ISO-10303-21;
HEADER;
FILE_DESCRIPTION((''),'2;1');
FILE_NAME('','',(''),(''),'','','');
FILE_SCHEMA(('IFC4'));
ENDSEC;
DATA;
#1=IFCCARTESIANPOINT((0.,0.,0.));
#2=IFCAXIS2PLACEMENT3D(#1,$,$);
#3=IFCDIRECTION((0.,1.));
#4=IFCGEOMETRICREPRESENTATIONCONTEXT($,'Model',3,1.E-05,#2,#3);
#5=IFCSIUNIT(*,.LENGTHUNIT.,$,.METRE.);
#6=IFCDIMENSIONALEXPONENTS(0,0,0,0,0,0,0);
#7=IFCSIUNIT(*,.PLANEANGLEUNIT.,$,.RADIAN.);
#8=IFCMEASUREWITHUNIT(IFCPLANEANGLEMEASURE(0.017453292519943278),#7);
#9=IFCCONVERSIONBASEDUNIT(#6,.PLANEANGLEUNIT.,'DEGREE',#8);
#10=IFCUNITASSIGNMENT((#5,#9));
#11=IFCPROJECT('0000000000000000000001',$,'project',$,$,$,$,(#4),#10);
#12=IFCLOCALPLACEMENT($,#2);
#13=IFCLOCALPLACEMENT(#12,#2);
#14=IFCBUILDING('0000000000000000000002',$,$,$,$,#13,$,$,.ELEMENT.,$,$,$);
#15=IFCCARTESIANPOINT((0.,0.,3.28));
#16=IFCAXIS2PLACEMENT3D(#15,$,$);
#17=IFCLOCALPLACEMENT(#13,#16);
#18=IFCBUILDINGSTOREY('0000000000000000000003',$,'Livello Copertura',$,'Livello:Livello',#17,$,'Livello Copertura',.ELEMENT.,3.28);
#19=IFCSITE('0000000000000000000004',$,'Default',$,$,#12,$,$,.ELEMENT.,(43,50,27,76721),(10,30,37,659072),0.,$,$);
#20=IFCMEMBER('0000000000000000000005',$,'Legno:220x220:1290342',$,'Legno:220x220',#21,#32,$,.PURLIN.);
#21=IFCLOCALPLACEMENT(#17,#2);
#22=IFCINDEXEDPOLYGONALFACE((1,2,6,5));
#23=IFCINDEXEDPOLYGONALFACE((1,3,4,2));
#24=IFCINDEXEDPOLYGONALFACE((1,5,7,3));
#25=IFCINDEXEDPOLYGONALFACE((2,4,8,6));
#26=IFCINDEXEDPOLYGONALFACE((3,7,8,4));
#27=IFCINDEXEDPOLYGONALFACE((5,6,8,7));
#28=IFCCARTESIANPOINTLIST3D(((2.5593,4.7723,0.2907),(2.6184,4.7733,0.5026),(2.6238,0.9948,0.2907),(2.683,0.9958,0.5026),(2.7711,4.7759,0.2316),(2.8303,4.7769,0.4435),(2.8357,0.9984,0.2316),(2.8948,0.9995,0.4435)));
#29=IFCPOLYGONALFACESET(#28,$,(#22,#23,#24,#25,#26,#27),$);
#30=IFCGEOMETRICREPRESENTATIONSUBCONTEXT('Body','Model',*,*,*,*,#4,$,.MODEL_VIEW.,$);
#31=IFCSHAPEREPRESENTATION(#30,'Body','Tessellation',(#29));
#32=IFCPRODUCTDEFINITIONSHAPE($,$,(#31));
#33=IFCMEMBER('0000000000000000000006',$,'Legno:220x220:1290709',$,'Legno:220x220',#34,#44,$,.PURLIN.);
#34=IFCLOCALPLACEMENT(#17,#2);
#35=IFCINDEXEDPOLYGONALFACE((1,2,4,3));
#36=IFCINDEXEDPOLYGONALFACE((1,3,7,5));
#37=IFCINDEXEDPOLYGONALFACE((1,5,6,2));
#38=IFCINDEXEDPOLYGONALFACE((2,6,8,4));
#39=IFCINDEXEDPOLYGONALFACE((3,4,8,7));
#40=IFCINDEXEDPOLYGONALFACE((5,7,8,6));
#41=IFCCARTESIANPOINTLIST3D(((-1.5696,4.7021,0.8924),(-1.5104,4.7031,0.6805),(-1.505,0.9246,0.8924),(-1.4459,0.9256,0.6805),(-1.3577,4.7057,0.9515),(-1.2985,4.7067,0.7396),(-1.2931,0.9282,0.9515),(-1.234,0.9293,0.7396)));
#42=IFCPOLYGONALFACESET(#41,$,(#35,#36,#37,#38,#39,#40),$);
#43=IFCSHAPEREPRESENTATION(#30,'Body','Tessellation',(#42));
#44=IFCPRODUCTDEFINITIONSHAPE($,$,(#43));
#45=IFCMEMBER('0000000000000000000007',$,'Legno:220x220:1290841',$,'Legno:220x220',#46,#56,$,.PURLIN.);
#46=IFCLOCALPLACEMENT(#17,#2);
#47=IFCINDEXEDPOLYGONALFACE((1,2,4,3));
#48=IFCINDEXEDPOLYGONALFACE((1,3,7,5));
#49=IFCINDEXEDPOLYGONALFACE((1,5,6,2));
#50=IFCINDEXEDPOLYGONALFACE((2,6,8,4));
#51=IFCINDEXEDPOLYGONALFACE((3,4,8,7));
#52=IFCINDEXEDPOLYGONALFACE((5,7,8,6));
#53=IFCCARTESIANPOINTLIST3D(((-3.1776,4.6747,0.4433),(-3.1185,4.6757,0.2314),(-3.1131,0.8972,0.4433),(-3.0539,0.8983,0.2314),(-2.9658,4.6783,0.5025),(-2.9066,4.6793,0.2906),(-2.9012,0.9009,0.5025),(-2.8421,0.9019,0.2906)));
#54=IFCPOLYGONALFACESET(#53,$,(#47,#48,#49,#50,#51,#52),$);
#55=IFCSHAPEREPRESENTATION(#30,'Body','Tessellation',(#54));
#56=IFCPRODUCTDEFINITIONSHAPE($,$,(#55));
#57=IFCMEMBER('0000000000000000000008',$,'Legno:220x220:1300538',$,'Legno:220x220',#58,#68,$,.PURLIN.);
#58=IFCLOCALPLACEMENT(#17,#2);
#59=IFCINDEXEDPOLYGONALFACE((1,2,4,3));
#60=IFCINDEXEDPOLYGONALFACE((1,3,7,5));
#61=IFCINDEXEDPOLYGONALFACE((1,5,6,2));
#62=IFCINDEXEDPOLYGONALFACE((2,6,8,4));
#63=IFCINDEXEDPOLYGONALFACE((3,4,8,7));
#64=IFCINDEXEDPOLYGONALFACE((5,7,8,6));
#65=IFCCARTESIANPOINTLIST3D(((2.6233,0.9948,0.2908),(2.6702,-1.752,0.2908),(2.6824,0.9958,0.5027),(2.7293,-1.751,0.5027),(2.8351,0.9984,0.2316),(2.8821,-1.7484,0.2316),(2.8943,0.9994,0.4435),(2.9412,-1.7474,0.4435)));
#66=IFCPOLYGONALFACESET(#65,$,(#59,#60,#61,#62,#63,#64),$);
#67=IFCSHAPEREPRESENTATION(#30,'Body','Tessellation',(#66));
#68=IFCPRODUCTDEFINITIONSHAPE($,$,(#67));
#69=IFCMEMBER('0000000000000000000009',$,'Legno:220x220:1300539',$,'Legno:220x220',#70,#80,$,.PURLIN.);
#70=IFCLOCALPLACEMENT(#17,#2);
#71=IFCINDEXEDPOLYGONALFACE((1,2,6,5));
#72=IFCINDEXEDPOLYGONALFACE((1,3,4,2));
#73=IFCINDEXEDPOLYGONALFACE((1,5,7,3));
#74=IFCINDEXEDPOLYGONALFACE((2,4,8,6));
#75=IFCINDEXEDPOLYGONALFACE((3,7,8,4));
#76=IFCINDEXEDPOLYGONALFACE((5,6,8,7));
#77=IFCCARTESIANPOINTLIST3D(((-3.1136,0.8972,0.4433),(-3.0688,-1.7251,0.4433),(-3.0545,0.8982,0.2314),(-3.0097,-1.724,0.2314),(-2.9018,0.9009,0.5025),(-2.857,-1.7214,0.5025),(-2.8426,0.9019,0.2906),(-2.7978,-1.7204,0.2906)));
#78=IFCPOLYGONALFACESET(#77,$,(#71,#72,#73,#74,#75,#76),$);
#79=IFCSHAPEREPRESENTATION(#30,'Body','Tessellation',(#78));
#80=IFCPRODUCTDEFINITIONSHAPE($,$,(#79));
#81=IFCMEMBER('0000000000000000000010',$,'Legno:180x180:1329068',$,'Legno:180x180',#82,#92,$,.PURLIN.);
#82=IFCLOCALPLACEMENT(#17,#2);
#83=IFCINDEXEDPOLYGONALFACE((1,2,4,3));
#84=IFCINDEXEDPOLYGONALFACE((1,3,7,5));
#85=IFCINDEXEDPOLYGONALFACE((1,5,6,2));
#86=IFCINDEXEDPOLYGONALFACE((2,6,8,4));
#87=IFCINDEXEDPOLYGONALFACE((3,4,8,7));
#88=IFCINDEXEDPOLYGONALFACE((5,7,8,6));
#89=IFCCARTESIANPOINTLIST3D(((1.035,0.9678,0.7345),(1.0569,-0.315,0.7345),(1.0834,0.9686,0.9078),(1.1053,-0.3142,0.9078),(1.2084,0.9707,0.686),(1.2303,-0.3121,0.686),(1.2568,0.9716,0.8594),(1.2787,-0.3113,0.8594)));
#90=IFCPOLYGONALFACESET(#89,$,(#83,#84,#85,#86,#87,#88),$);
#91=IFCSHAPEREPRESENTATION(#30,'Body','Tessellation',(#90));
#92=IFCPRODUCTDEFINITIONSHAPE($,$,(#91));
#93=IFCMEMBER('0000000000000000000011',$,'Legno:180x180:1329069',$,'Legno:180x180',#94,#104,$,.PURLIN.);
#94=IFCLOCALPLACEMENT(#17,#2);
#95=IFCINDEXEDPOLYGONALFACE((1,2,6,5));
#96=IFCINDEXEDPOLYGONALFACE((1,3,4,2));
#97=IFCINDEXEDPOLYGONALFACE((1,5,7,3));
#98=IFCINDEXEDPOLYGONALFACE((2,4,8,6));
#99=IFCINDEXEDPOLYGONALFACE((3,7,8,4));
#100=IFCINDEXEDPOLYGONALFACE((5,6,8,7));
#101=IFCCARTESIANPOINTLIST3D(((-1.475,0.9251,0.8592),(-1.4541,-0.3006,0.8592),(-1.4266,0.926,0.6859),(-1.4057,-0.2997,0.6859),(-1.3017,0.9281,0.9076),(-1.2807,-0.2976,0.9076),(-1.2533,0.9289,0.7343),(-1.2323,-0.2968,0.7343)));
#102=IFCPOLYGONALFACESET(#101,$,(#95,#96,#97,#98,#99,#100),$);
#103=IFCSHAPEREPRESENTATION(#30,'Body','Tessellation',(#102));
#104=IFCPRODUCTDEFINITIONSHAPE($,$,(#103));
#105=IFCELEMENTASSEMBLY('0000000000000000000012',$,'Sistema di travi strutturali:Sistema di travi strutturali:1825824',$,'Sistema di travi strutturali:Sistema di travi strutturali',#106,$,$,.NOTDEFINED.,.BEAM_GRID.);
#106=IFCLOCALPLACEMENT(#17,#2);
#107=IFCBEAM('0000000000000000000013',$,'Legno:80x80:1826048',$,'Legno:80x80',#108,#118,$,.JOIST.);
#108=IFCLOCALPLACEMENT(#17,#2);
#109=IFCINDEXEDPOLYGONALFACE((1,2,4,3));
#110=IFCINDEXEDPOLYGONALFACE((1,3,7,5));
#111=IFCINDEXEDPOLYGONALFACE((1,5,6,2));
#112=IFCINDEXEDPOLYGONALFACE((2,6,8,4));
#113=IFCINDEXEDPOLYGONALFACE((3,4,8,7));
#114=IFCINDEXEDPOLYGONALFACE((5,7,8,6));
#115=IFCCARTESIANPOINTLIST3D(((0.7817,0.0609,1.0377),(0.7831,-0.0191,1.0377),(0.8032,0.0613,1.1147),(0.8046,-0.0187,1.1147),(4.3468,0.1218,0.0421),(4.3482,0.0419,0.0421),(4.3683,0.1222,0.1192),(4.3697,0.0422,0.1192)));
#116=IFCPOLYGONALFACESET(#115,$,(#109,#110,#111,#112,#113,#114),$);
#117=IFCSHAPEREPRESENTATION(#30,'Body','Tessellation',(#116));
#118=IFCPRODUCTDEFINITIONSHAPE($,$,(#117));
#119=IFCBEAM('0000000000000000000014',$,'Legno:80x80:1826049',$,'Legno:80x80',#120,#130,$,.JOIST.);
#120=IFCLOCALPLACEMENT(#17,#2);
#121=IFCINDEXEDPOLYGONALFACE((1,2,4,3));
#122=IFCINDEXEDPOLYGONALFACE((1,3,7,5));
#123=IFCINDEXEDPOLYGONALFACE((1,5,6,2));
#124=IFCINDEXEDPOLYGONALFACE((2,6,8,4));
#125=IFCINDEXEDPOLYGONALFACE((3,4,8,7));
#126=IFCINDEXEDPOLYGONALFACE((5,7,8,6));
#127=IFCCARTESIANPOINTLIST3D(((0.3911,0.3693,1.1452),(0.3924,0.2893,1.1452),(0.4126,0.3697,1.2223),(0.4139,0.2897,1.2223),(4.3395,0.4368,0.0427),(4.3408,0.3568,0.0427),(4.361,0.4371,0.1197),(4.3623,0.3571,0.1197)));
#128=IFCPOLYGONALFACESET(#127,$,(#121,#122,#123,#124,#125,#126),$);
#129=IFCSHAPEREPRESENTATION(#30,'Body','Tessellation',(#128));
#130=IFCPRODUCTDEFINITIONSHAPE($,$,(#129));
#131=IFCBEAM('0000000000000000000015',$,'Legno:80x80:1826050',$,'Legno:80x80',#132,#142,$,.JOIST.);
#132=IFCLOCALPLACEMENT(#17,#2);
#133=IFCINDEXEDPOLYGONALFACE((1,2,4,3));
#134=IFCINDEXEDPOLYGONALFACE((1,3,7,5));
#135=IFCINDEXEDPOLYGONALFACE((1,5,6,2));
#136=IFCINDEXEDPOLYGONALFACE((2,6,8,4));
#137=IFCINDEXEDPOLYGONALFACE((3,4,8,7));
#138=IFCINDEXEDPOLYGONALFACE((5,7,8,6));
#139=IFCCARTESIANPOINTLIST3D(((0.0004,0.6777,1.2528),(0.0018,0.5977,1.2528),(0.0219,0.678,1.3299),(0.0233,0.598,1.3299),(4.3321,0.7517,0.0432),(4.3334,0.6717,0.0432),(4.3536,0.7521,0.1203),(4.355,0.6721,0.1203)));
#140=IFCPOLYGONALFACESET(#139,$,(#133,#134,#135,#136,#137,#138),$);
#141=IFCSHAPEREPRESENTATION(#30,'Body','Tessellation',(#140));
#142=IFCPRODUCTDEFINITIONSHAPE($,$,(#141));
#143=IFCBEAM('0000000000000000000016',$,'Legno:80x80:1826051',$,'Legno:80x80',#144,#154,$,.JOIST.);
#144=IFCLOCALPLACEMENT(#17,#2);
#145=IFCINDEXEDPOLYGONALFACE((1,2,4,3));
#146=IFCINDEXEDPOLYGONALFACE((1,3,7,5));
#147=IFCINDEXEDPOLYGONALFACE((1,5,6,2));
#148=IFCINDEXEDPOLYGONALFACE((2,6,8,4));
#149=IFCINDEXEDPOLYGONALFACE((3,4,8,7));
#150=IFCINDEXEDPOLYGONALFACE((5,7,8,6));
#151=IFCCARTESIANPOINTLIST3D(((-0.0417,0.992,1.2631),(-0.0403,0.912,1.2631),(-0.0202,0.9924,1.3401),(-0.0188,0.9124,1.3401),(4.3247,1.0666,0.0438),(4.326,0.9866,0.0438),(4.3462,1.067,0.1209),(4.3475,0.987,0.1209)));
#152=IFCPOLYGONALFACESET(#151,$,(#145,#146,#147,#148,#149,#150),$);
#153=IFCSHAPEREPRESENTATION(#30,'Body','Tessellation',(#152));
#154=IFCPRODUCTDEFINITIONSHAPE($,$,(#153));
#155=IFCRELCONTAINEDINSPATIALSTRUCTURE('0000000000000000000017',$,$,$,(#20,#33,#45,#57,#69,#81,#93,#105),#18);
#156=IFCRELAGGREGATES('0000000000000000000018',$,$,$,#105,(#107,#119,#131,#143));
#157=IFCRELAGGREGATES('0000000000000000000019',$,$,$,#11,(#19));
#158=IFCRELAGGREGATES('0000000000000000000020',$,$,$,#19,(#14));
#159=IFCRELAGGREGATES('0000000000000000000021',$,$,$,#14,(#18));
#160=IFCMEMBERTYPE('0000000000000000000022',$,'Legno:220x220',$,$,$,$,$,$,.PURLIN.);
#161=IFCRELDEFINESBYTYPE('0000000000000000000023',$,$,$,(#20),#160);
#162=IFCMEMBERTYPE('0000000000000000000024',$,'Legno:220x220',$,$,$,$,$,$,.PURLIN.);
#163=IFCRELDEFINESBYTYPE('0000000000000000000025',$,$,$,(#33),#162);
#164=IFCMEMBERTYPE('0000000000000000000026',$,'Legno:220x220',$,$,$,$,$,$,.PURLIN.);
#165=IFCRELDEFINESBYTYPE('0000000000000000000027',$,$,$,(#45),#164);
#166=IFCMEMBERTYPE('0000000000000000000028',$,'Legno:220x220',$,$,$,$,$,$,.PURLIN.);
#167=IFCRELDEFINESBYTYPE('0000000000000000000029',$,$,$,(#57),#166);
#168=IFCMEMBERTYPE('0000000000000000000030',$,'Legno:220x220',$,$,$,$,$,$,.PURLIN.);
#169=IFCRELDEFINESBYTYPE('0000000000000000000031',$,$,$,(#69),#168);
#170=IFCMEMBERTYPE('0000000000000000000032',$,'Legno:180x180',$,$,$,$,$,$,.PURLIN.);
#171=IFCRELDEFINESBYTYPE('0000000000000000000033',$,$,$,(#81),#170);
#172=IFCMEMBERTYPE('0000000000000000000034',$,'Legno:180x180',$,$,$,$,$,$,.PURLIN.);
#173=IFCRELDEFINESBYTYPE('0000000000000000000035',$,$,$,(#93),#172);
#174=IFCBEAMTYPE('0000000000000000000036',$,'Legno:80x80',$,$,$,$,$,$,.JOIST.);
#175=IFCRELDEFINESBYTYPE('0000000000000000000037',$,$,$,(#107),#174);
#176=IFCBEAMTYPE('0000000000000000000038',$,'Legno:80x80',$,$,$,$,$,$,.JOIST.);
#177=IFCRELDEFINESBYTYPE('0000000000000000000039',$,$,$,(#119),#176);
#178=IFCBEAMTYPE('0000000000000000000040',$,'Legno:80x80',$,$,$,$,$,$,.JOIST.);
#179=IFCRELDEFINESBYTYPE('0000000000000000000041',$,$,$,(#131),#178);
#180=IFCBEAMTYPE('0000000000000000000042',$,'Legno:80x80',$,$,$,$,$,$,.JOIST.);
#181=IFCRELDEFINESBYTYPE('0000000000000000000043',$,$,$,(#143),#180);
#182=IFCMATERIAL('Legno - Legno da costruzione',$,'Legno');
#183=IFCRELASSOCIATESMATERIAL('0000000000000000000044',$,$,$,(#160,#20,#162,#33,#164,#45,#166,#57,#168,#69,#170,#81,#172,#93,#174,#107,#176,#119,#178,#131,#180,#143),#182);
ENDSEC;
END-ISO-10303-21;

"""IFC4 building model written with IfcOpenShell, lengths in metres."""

from ifc_helpers import new_model, entity, si_unit, converted_unit, direction, frame, origin, place, context, subcontext, project, spatial, indexed_curve, outline, extrude, source, transform, mapped, material, type_object, type_shapes, element, aggregate, save


model = new_model("IFC4")

# Units and contexts
model_context = context("Model", 3, precision=1e-05, world=origin(), true_north=direction((0.0, 1.0)))
body_context = subcontext(model_context, "Body", "Model", "MODEL_VIEW")
ifc_project = project(units=[si_unit("LENGTHUNIT", "METRE"), converted_unit("PLANEANGLEUNIT", "DEGREE", entity("IfcPlaneAngleMeasure", 0.017453292519943278), si_unit("PLANEANGLEUNIT", "RADIAN"), dimensions=[0, 0, 0, 0, 0, 0, 0])], contexts=[model_context])

# Site, building, storey
site_placement = place(None, origin())
site = spatial("IfcSite", under=ifc_project, at=site_placement, Name="Default", CompositionType="ELEMENT", RefLatitude=(43, 50, 27, 76721), RefLongitude=(10, 30, 37, 659072), RefElevation=0.0)
building_placement = place(site_placement, origin())
building = spatial("IfcBuilding", under=site, at=building_placement, CompositionType="ELEMENT")
storey_placement = place(building_placement, frame((0.0, 0.0, 3.28)))
storey = spatial("IfcBuildingStorey", under=building, at=storey_placement, Name="Livello Copertura", ObjectType="Livello:Livello", LongName="Livello Copertura", CompositionType="ELEMENT", Elevation=3.28)

# Members
ifc_material = material(Name="Legno - Legno da costruzione", Category="Legno")
member_type_1 = type_object("IfcMemberType", Name="Legno:220x220", PredefinedType="PURLIN", material=ifc_material)
shared_shape_1 = source(origin(), body_context, "Body", "SweptSolid", [
    extrude(outline(indexed_curve([(-0.11, -0.11), (0.11, -0.11), (0.11, 0.11), (-0.11, 0.11), (-0.11, -0.11)], self_intersect=False)), frame((2.6948, 4.7746, 3.6471), z_axis=(0.017085, -0.999854, 0.0), x_axis=(-0.963022, -0.016456, 0.26892)), (0.0, 0.0, 1.0), 3.778),
])
type_shapes(member_type_1, [shared_shape_1])
member_1_placement = place(storey_placement, frame((0.0, 0.0, -3.28)))
element("IfcMember", 1, at=member_1_placement, inside=storey, type_object=member_type_1, material=ifc_material, Name="Legno:220x220:1290342", ObjectType="Legno:220x220", PredefinedType="PURLIN", context=body_context, shape_type="MappedRepresentation", body=[
    mapped(shared_shape_1, transform((0.0, 0.0, 0.0), scale=1.0)),
])
member_type_2 = type_object("IfcMemberType", Name="Legno:220x220", PredefinedType="PURLIN", material=ifc_material)
shared_shape_2 = source(origin(), body_context, "Body", "SweptSolid", [
    extrude(outline(indexed_curve([(-0.11, -0.11), (0.11, -0.11), (0.11, 0.11), (-0.11, 0.11), (-0.11, -0.11)], self_intersect=False)), frame((-1.434, 4.7044, 4.096), z_axis=(0.017085, -0.999854, 0.0), x_axis=(-0.963022, -0.016456, -0.26892)), (0.0, 0.0, 1.0), 3.778),
])
type_shapes(member_type_2, [shared_shape_2])
member_2_placement = place(storey_placement, frame((0.0, 0.0, -3.28)))
element("IfcMember", 2, at=member_2_placement, inside=storey, type_object=member_type_2, material=ifc_material, Name="Legno:220x220:1290709", ObjectType="Legno:220x220", PredefinedType="PURLIN", context=body_context, shape_type="MappedRepresentation", body=[
    mapped(shared_shape_2, transform((0.0, 0.0, 0.0), scale=1.0)),
])
member_type_3 = type_object("IfcMemberType", Name="Legno:220x220", PredefinedType="PURLIN", material=ifc_material)
shared_shape_3 = source(origin(), body_context, "Body", "SweptSolid", [
    extrude(outline(indexed_curve([(-0.11, -0.11), (0.11, -0.11), (0.11, 0.11), (-0.11, 0.11), (-0.11, -0.11)], self_intersect=False)), frame((-3.0421, 4.677, 3.647), z_axis=(0.017085, -0.999854, 0.0), x_axis=(-0.963022, -0.016456, -0.26892)), (0.0, 0.0, 1.0), 3.778),
])
type_shapes(member_type_3, [shared_shape_3])
member_3_placement = place(storey_placement, frame((0.0, 0.0, -3.28)))
element("IfcMember", 3, at=member_3_placement, inside=storey, type_object=member_type_3, material=ifc_material, Name="Legno:220x220:1290841", ObjectType="Legno:220x220", PredefinedType="PURLIN", context=body_context, shape_type="MappedRepresentation", body=[
    mapped(shared_shape_3, transform((0.0, 0.0, 0.0), scale=1.0)),
])
member_type_4 = type_object("IfcMemberType", Name="Legno:220x220", PredefinedType="PURLIN", material=ifc_material)
shared_shape_4 = source(origin(), body_context, "Body", "SweptSolid", [
    extrude(outline(indexed_curve([(-0.11, -0.11), (0.11, -0.11), (0.11, 0.11), (-0.11, 0.11), (-0.11, -0.11)], self_intersect=False)), frame((2.7588, 0.9971, 3.6471), z_axis=(0.017085, -0.999854, 0.0), x_axis=(-0.963022, -0.016456, 0.26892)), (0.0, 0.0, 1.0), 2.7472),
])
type_shapes(member_type_4, [shared_shape_4])
member_4_placement = place(storey_placement, frame((0.0, 0.0, -3.28)))
element("IfcMember", 4, at=member_4_placement, inside=storey, type_object=member_type_4, material=ifc_material, Name="Legno:220x220:1300538", ObjectType="Legno:220x220", PredefinedType="PURLIN", context=body_context, shape_type="MappedRepresentation", body=[
    mapped(shared_shape_4, transform((0.0, 0.0, 0.0), scale=1.0)),
])
member_type_5 = type_object("IfcMemberType", Name="Legno:220x220", PredefinedType="PURLIN", material=ifc_material)
shared_shape_5 = source(origin(), body_context, "Body", "SweptSolid", [
    extrude(outline(indexed_curve([(-0.11, -0.11), (0.11, -0.11), (0.11, 0.11), (-0.11, 0.11), (-0.11, -0.11)], self_intersect=False)), frame((-2.9781, 0.8995, 3.647), z_axis=(0.017085, -0.999854, 0.0), x_axis=(-0.963022, -0.016456, -0.26892)), (0.0, 0.0, 1.0), 2.6227),
])
type_shapes(member_type_5, [shared_shape_5])
member_5_placement = place(storey_placement, frame((0.0, 0.0, -3.28)))
element("IfcMember", 5, at=member_5_placement, inside=storey, type_object=member_type_5, material=ifc_material, Name="Legno:220x220:1300539", ObjectType="Legno:220x220", PredefinedType="PURLIN", context=body_context, shape_type="MappedRepresentation", body=[
    mapped(shared_shape_5, transform((0.0, 0.0, 0.0), scale=1.0)),
])
member_type_6 = type_object("IfcMemberType", Name="Legno:180x180", PredefinedType="PURLIN", material=ifc_material)
shared_shape_6 = source(origin(), body_context, "Body", "SweptSolid", [
    extrude(outline(indexed_curve([(-0.09, -0.09), (0.09, -0.09), (0.09, 0.09), (-0.09, 0.09), (-0.09, -0.09)], self_intersect=False)), frame((1.1459, 0.9697, 4.0769), z_axis=(0.017085, -0.999854, 0.0), x_axis=(-0.963022, -0.016456, 0.26892)), (0.0, 0.0, 1.0), 1.283),
])
type_shapes(member_type_6, [shared_shape_6])
member_6_placement = place(storey_placement, frame((0.0, 0.0, -3.28)))
element("IfcMember", 6, at=member_6_placement, inside=storey, type_object=member_type_6, material=ifc_material, Name="Legno:180x180:1329068", ObjectType="Legno:180x180", PredefinedType="PURLIN", context=body_context, shape_type="MappedRepresentation", body=[
    mapped(shared_shape_6, transform((0.0, 0.0, 0.0), scale=1.0)),
])
member_type_7 = type_object("IfcMemberType", Name="Legno:180x180", PredefinedType="PURLIN", material=ifc_material)
shared_shape_7 = source(origin(), body_context, "Body", "SweptSolid", [
    extrude(outline(indexed_curve([(-0.09, -0.09), (0.09, -0.09), (0.09, 0.09), (-0.09, 0.09), (-0.09, -0.09)], self_intersect=False)), frame((-1.3641, 0.927, 4.0767), z_axis=(0.017085, -0.999854, 0.0), x_axis=(-0.963022, -0.016456, -0.26892)), (0.0, 0.0, 1.0), 1.2259),
])
type_shapes(member_type_7, [shared_shape_7])
member_7_placement = place(storey_placement, frame((0.0, 0.0, -3.28)))
element("IfcMember", 7, at=member_7_placement, inside=storey, type_object=member_type_7, material=ifc_material, Name="Legno:180x180:1329069", ObjectType="Legno:180x180", PredefinedType="PURLIN", context=body_context, shape_type="MappedRepresentation", body=[
    mapped(shared_shape_7, transform((0.0, 0.0, 0.0), scale=1.0)),
])

# Element assembly, beams
assembly_1_placement = place(storey_placement, origin())
assembly_1 = element("IfcElementAssembly", 8, at=assembly_1_placement, inside=storey, Name="Sistema di travi strutturali:Sistema di travi strutturali:1825824", ObjectType="Sistema di travi strutturali:Sistema di travi strutturali", AssemblyPlace="NOTDEFINED", PredefinedType="BEAM_GRID")
beam_type_1 = type_object("IfcBeamType", Name="Legno:80x80", PredefinedType="JOIST", material=ifc_material)
shared_shape_8 = source(origin(), body_context, "Body", "SweptSolid", [
    extrude(outline(indexed_curve([(-1.851, -0.04), (1.851, -0.04), (1.851, 0.04), (-1.851, 0.04), (-1.851, -0.04)], self_intersect=False)), frame((0.0, 0.0, -0.04), z_axis=(0.0, 0.0, 1.0), x_axis=(-1.0, 0.0, 0.0)), (0.0, 0.0, 1.0), 0.08),
])
type_shapes(beam_type_1, [shared_shape_8])
beam_1_placement = place(assembly_1_placement, frame((2.5757, 0.0516, 0.5784), z_axis=(0.268881, 0.004594, 0.963163), x_axis=(-0.963022, -0.016456, 0.26892)))
beam_1 = element("IfcBeam", 9, at=beam_1_placement, type_object=beam_type_1, material=ifc_material, Name="Legno:80x80:1826048", ObjectType="Legno:80x80", PredefinedType="JOIST", context=body_context, shape_type="MappedRepresentation", body=[
    mapped(shared_shape_8, transform((0.0, 0.0, 0.0), scale=1.0)),
])
beam_type_2 = type_object("IfcBeamType", Name="Legno:80x80", PredefinedType="JOIST", material=ifc_material)
shared_shape_9 = source(origin(), body_context, "Body", "SweptSolid", [
    extrude(outline(indexed_curve([(-2.05, -0.04), (2.05, -0.04), (2.05, 0.04), (-2.05, 0.04), (-2.05, -0.04)], self_intersect=False)), frame((0.0, 0.0, -0.04), z_axis=(0.0, 0.0, 1.0), x_axis=(-1.0, 0.0, 0.0)), (0.0, 0.0, 1.0), 0.08),
])
type_shapes(beam_type_2, [shared_shape_9])
beam_2_placement = place(assembly_1_placement, frame((2.3767, 0.3632, 0.6325), z_axis=(0.268881, 0.004594, 0.963163), x_axis=(-0.963022, -0.016456, 0.26892)))
beam_2 = element("IfcBeam", 10, at=beam_2_placement, type_object=beam_type_2, material=ifc_material, Name="Legno:80x80:1826049", ObjectType="Legno:80x80", PredefinedType="JOIST", context=body_context, shape_type="MappedRepresentation", body=[
    mapped(shared_shape_9, transform((0.0, 0.0, 0.0), scale=1.0)),
])
beam_type_3 = type_object("IfcBeamType", Name="Legno:80x80", PredefinedType="JOIST", material=ifc_material)
shared_shape_10 = source(origin(), body_context, "Body", "SweptSolid", [
    extrude(outline(indexed_curve([(-2.249, -0.04), (2.249, -0.04), (2.249, 0.04), (-2.249, 0.04), (-2.249, -0.04)], self_intersect=False)), frame((0.0, 0.0, -0.04), z_axis=(0.0, 0.0, 1.0), x_axis=(-1.0, 0.0, 0.0)), (0.0, 0.0, 1.0), 0.08),
])
type_shapes(beam_type_3, [shared_shape_10])
beam_3_placement = place(assembly_1_placement, frame((2.1777, 0.6749, 0.6866), z_axis=(0.268881, 0.004594, 0.963163), x_axis=(-0.963022, -0.016456, 0.26892)))
beam_3 = element("IfcBeam", 11, at=beam_3_placement, type_object=beam_type_3, material=ifc_material, Name="Legno:80x80:1826050", ObjectType="Legno:80x80", PredefinedType="JOIST", context=body_context, shape_type="MappedRepresentation", body=[
    mapped(shared_shape_10, transform((0.0, 0.0, 0.0), scale=1.0)),
])
beam_type_4 = type_object("IfcBeamType", Name="Legno:80x80", PredefinedType="JOIST", material=ifc_material)
shared_shape_11 = source(origin(), body_context, "Body", "SweptSolid", [
    extrude(outline(indexed_curve([(-2.267, -0.04), (2.267, -0.04), (2.267, 0.04), (-2.267, 0.04), (-2.267, -0.04)], self_intersect=False)), frame((0.0, 0.0, -0.04), z_axis=(0.0, 0.0, 1.0), x_axis=(-1.0, 0.0, 0.0)), (0.0, 0.0, 1.0), 0.08),
])
type_shapes(beam_type_4, [shared_shape_11])
beam_4_placement = place(assembly_1_placement, frame((2.1529, 0.9895, 0.692), z_axis=(0.268881, 0.004594, 0.963163), x_axis=(-0.963022, -0.016456, 0.26892)))
beam_4 = element("IfcBeam", 12, at=beam_4_placement, type_object=beam_type_4, material=ifc_material, Name="Legno:80x80:1826051", ObjectType="Legno:80x80", PredefinedType="JOIST", context=body_context, shape_type="MappedRepresentation", body=[
    mapped(shared_shape_11, transform((0.0, 0.0, 0.0), scale=1.0)),
])
aggregate(assembly_1, [beam_1, beam_2, beam_3, beam_4])

save(model, "model.ifc")
